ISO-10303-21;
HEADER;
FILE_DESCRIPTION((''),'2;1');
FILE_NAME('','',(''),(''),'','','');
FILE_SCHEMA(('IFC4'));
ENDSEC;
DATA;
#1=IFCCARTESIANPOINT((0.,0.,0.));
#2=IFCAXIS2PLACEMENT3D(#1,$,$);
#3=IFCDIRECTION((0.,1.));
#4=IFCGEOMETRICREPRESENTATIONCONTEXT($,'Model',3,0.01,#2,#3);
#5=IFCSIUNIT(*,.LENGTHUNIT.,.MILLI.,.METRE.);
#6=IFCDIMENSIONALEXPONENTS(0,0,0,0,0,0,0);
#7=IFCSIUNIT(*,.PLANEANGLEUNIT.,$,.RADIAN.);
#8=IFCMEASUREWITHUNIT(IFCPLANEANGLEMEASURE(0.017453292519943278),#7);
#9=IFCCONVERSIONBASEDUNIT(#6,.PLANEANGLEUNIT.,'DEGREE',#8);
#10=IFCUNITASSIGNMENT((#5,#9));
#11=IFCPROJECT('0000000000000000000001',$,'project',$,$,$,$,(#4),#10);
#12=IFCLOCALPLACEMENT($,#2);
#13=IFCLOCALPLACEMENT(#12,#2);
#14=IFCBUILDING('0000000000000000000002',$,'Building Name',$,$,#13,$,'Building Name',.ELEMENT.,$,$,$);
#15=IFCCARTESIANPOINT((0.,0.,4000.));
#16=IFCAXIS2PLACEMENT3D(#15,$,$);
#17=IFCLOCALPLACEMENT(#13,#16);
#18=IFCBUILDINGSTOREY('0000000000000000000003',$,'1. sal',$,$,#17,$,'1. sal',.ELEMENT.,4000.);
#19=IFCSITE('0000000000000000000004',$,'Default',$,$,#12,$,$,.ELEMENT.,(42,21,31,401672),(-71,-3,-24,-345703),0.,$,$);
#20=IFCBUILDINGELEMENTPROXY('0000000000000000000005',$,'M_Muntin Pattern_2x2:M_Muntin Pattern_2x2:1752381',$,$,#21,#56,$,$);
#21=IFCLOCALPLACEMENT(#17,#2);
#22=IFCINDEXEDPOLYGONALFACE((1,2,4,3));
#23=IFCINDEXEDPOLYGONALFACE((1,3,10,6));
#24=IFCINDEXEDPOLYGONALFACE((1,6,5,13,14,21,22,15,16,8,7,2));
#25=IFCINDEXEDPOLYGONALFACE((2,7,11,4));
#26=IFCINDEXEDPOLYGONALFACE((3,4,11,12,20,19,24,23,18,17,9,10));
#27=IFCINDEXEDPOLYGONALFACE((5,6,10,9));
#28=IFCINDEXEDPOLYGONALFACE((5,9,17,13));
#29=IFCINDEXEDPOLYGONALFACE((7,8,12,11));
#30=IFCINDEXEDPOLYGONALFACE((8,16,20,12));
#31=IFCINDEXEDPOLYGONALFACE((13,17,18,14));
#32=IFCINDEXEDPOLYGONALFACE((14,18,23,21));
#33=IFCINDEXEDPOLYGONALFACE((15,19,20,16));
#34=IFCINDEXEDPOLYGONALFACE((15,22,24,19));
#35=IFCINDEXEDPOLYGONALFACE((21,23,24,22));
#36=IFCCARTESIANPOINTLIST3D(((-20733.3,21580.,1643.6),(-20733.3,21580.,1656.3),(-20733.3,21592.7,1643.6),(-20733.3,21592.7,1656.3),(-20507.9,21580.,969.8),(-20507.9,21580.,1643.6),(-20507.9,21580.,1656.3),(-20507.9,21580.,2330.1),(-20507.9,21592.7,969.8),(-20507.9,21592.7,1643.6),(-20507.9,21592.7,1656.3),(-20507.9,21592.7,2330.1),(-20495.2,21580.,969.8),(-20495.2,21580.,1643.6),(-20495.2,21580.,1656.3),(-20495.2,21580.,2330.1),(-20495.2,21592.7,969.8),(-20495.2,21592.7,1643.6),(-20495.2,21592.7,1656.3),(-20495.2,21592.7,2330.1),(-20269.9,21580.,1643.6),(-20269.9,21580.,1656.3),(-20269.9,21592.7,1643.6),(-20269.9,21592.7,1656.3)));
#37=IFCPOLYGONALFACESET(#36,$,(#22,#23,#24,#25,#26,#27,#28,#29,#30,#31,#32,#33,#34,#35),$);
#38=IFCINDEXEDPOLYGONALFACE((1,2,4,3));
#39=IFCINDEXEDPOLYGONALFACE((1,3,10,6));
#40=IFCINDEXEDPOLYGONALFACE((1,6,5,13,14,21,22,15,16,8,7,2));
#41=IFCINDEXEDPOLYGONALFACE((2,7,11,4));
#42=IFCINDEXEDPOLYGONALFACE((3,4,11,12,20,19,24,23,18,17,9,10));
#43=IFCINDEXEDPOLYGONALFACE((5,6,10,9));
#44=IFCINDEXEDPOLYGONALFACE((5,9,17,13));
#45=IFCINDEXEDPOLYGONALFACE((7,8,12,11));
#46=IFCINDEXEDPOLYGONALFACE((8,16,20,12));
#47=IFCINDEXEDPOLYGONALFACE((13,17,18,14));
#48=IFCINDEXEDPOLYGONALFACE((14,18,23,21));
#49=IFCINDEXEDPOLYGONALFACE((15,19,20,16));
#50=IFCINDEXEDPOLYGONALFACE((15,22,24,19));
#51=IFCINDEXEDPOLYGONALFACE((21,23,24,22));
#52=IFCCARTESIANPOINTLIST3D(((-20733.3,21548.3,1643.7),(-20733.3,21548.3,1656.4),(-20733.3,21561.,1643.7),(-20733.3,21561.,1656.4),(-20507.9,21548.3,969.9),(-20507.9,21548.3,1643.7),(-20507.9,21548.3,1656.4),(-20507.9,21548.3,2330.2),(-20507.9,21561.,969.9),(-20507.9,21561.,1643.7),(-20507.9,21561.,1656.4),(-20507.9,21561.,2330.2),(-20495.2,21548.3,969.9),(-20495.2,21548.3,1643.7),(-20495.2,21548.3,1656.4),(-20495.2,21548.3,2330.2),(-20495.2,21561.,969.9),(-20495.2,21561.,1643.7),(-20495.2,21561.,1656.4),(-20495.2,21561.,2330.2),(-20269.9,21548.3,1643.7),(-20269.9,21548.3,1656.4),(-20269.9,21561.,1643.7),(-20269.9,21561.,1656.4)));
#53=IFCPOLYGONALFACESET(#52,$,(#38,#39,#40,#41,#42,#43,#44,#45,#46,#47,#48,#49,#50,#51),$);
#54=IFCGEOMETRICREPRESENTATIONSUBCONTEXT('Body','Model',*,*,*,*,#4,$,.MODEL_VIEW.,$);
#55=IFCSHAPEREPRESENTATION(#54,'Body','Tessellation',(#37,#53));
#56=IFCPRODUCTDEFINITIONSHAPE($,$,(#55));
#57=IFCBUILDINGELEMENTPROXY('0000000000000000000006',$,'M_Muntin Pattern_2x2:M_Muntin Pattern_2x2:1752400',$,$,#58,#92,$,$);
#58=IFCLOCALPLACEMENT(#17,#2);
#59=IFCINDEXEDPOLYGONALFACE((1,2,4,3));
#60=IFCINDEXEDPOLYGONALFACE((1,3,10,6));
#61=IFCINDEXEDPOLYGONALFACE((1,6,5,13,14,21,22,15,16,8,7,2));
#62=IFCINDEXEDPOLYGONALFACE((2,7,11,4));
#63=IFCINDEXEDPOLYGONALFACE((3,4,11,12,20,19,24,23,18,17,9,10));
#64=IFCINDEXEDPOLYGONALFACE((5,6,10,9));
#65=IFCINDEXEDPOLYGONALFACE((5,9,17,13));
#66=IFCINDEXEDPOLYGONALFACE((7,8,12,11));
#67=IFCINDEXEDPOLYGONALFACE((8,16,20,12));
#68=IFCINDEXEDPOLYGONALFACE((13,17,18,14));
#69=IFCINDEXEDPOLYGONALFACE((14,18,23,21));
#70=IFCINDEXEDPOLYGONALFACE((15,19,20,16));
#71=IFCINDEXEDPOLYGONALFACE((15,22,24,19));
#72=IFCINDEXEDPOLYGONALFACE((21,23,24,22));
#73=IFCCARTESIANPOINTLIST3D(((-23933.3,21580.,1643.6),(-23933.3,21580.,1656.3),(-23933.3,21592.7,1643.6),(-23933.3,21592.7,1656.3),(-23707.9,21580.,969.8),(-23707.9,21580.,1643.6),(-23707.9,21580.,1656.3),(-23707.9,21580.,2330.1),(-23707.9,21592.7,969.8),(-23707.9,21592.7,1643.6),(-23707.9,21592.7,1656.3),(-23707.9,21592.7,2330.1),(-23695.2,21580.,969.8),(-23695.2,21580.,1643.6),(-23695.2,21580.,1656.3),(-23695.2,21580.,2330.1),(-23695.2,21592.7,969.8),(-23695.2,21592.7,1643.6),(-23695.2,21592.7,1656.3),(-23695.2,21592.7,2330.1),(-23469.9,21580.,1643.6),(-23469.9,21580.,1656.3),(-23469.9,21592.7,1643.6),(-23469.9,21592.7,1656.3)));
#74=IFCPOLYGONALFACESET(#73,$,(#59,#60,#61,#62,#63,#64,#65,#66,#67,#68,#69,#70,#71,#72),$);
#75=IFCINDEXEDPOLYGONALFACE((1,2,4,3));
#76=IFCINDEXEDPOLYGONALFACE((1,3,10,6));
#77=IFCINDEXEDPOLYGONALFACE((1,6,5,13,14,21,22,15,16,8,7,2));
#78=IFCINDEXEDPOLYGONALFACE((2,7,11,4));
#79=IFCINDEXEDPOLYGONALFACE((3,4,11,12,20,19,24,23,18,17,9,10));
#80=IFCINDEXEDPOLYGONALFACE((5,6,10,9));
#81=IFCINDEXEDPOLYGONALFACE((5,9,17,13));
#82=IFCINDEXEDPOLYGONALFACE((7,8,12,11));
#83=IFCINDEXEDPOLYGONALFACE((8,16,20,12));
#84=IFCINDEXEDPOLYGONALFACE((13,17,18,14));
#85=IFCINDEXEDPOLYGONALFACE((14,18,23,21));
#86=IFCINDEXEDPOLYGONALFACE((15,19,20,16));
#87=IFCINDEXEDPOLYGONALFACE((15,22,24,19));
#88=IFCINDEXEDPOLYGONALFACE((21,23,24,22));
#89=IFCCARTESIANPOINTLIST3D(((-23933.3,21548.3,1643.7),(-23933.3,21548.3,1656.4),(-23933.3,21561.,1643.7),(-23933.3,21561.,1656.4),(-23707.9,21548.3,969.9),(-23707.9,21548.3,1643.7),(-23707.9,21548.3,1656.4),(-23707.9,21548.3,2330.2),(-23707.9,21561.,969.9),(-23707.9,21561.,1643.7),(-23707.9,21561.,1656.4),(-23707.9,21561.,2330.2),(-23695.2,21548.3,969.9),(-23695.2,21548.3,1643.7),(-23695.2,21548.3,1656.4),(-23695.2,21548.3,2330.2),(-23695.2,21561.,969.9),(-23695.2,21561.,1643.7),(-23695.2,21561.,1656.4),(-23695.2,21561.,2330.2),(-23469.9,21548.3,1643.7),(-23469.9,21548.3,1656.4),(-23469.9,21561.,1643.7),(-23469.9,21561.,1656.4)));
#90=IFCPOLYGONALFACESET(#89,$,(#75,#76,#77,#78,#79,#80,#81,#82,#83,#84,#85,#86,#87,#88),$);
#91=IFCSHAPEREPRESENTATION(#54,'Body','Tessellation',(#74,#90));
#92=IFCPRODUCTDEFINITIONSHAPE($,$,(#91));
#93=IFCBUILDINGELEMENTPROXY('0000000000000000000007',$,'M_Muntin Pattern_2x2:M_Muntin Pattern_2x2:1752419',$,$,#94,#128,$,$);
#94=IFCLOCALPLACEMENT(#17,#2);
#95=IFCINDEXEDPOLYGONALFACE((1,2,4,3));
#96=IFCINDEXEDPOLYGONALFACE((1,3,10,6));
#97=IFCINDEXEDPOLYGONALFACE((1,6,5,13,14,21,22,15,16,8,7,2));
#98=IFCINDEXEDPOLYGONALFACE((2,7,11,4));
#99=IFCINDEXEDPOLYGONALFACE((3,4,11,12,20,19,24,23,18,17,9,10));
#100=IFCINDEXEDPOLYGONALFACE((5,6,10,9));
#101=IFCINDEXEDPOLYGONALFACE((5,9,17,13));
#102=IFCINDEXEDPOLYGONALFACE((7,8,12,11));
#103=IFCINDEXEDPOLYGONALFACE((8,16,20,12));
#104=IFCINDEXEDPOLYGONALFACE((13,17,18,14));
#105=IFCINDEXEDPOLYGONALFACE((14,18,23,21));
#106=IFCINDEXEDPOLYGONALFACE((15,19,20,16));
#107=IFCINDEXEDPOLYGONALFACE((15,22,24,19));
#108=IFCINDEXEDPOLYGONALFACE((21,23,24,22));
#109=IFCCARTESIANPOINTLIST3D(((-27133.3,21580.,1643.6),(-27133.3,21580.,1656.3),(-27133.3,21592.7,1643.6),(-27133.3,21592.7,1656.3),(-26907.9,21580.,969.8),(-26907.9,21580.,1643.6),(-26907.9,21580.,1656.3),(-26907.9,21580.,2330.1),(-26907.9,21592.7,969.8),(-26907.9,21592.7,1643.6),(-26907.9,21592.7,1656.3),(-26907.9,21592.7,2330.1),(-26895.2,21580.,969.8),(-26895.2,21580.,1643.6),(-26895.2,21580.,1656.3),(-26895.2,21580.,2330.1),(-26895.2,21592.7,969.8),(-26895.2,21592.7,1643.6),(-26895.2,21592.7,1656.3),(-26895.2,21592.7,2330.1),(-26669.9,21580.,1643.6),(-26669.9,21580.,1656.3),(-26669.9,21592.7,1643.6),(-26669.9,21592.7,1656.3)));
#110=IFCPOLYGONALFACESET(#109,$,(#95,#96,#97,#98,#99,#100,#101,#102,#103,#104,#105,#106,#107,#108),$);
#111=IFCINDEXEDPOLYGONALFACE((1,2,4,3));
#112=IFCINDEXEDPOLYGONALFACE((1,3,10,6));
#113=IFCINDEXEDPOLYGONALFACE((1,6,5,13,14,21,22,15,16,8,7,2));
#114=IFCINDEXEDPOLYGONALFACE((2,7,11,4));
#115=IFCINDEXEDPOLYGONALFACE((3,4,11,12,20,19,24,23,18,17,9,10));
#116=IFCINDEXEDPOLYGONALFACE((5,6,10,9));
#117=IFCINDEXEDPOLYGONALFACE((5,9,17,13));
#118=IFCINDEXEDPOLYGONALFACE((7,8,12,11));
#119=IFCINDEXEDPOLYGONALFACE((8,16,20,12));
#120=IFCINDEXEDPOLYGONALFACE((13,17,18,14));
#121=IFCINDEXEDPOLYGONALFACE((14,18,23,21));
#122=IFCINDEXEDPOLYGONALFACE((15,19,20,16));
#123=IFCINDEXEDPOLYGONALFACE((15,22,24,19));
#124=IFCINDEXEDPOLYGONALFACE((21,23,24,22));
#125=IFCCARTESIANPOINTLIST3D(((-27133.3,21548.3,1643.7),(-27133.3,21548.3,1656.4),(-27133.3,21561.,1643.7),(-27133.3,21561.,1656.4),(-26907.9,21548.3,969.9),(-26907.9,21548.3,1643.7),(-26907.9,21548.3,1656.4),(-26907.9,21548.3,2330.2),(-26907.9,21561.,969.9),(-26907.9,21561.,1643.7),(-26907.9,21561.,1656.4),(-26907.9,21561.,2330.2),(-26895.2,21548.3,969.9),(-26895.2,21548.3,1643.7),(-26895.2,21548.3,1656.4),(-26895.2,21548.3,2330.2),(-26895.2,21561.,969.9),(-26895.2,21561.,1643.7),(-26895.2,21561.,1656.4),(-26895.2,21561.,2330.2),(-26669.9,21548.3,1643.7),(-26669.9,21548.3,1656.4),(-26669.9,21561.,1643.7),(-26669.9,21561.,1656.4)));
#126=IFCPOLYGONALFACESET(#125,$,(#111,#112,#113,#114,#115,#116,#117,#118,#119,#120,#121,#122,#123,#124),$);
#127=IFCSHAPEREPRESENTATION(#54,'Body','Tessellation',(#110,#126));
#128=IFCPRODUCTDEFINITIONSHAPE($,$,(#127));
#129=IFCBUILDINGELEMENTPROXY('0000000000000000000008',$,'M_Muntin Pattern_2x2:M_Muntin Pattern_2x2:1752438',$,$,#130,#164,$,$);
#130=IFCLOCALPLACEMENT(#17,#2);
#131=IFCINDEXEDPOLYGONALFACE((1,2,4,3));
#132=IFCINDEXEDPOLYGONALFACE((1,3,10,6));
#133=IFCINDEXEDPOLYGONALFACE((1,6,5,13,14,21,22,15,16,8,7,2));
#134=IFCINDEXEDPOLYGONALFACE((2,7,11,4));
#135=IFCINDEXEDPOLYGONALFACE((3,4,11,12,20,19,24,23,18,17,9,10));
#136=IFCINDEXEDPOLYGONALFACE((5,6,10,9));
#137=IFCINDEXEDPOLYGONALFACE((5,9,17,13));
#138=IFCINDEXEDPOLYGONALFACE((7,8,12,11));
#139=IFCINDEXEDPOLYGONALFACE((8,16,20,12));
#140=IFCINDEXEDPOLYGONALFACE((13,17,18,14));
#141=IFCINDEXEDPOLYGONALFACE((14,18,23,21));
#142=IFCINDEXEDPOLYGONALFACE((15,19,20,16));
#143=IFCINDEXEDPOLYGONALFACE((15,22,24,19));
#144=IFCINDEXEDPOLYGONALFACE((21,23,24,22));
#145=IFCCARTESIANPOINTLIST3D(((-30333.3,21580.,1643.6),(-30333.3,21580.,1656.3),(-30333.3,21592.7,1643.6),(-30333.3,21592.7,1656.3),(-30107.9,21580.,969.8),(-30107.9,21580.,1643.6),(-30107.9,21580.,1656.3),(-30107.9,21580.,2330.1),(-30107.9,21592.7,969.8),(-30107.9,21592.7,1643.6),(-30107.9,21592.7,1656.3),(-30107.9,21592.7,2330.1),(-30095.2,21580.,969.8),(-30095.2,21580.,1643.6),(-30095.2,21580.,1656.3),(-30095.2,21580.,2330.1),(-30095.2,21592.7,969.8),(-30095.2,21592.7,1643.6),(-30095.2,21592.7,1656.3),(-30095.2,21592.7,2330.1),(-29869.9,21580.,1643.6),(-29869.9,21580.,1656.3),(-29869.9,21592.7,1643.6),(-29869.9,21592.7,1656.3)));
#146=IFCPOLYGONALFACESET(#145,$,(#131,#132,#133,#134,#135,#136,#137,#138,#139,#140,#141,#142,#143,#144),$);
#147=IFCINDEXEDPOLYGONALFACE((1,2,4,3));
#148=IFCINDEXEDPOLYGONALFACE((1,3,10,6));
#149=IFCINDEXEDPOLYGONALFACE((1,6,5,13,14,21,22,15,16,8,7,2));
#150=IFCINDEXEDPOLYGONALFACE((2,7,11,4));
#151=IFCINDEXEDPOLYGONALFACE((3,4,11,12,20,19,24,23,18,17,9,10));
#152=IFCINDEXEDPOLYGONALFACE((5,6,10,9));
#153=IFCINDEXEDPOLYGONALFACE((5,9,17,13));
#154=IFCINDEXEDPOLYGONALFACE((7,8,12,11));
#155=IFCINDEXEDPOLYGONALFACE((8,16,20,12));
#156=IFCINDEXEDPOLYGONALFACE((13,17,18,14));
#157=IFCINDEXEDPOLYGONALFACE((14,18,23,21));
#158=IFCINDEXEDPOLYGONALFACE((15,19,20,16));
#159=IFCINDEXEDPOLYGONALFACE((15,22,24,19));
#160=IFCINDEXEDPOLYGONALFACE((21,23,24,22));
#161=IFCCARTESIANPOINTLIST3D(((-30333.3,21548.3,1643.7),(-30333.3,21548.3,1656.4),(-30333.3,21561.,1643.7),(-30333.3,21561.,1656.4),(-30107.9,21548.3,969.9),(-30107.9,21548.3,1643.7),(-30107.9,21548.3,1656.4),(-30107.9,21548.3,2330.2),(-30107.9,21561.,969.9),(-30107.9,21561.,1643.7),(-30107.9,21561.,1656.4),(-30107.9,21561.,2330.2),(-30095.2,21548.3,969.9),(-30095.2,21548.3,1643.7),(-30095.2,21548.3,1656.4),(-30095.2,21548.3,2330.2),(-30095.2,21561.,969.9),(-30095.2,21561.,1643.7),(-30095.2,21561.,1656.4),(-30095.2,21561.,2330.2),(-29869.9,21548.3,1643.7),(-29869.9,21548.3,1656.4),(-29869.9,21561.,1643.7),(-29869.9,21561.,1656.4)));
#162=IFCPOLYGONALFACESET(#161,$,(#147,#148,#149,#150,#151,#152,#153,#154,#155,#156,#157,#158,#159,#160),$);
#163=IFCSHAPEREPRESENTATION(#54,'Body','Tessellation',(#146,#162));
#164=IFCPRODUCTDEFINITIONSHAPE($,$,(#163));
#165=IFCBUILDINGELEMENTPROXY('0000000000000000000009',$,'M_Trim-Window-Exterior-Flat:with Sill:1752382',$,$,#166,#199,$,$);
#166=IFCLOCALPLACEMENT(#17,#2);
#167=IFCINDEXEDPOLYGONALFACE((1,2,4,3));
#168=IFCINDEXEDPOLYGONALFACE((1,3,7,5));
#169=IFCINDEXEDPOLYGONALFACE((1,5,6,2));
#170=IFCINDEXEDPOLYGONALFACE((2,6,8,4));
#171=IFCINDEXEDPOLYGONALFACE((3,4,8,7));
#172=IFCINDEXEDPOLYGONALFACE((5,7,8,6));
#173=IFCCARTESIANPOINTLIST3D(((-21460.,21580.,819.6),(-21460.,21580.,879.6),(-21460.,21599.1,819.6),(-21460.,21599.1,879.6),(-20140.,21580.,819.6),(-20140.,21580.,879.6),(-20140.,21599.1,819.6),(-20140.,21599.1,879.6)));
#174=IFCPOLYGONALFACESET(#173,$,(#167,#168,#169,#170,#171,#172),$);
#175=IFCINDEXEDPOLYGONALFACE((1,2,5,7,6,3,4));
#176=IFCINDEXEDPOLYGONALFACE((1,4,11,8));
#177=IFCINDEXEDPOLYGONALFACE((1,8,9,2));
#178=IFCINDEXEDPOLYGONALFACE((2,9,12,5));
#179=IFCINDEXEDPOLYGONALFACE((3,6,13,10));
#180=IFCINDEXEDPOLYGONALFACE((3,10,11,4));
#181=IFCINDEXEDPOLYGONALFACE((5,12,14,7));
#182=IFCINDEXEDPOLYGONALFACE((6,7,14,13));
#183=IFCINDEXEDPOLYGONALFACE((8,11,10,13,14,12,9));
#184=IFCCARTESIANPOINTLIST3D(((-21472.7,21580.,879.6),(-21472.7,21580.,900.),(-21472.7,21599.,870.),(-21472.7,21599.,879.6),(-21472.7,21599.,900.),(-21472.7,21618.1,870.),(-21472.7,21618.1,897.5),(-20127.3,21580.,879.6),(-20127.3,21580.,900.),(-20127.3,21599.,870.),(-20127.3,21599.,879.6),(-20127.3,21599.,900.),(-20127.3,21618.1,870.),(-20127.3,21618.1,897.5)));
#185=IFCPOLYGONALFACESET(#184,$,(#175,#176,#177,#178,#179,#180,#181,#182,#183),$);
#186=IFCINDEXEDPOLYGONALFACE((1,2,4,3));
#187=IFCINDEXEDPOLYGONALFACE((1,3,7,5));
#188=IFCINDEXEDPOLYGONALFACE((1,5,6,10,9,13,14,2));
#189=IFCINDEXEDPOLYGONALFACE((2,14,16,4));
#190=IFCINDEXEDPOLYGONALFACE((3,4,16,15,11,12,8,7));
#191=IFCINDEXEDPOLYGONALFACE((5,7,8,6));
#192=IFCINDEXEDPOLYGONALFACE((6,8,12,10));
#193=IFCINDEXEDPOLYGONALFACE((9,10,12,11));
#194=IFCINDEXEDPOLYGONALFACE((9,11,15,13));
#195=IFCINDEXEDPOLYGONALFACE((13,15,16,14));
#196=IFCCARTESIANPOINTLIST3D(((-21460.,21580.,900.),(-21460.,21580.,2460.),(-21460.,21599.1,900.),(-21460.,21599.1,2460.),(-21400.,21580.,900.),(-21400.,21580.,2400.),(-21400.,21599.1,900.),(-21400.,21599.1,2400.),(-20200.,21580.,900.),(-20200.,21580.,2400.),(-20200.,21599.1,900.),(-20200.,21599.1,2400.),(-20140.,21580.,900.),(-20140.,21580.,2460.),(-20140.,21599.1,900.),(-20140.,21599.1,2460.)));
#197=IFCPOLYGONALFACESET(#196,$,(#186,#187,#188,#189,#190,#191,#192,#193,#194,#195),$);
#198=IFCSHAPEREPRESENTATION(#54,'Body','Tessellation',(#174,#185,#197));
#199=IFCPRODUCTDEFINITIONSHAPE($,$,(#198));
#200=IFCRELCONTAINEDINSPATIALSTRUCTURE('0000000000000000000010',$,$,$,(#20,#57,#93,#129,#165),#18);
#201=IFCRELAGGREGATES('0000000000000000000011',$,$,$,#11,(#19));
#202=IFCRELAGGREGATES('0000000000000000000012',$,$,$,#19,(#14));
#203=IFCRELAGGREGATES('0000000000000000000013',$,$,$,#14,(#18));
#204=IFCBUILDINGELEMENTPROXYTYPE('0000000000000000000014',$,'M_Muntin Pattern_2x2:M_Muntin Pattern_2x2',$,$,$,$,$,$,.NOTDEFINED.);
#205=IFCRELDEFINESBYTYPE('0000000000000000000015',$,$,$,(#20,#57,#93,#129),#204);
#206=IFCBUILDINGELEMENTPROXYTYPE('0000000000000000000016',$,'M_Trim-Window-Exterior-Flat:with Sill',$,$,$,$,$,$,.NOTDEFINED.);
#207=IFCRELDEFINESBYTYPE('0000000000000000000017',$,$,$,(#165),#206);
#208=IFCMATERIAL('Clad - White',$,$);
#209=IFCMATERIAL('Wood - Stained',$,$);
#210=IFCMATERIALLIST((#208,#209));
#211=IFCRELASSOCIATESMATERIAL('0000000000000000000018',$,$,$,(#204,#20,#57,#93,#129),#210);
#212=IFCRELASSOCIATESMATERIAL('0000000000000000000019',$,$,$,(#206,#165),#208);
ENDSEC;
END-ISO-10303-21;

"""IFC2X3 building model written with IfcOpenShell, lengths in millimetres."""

from ifc_helpers import new_model, entity, si_unit, converted_unit, direction, frame, frame_2d, origin, place, context, subcontext, project, spatial, polyline, rectangle, outline, extrude, source, transform, mapped, material, material_list, type_object, type_shapes, element, save


model = new_model("IFC2X3")

# Units and contexts
model_context = context("Model", 3, precision=0.01, world=origin(), true_north=direction((0.0, 1.0)))
body_context = subcontext(model_context, "Body", "Model", "MODEL_VIEW")
ifc_project = project(units=[si_unit("LENGTHUNIT", "METRE", prefix="MILLI"), converted_unit("PLANEANGLEUNIT", "DEGREE", entity("IfcPlaneAngleMeasure", 0.017453292519943278), si_unit("PLANEANGLEUNIT", "RADIAN"), dimensions=[0, 0, 0, 0, 0, 0, 0])], contexts=[model_context])

# Site, building, storey
site_placement = place(None, origin())
site = spatial("IfcSite", under=ifc_project, at=site_placement, Name="Default", CompositionType="ELEMENT", RefLatitude=(42, 21, 31, 401672), RefLongitude=(-71, -3, -24, -345703), RefElevation=0.0)
building_placement = place(site_placement, origin())
building = spatial("IfcBuilding", under=site, at=building_placement, Name="Building Name", LongName="Building Name", CompositionType="ELEMENT")
storey_placement = place(building_placement, frame((0.0, 0.0, 4000.0)))
storey = spatial("IfcBuildingStorey", under=building, at=storey_placement, Name="1. sal", LongName="1. sal", CompositionType="ELEMENT", Elevation=4000.0)

# Building element proxies
ifc_material_1 = material(Name="Clad - White")
ifc_material_2 = material(Name="Wood - Stained")
ifc_material_list = material_list([ifc_material_1, ifc_material_2])
building_element_proxy_type_1 = type_object("IfcBuildingElementProxyType", Name="M_Muntin Pattern_2x2:M_Muntin Pattern_2x2", PredefinedType="NOTDEFINED", material=ifc_material_list)
shared_shape_1 = source(origin(), body_context, "Body", "SweptSolid", [
    extrude(outline(polyline([(6.4, -6.4), (680.1, -6.4), (680.1, 6.3), (6.4, 6.3), (6.4, 231.7), (-6.3, 231.7), (-6.3, 6.3), (-680.2, 6.3), (-680.2, -6.4), (-6.3, -6.4), (-6.3, -231.7), (6.4, -231.7), (6.4, -6.4)])), frame((0.0, -22.2, 680.1), z_axis=(0.0, 1.0, 0.0), x_axis=(0.0, 0.0, 1.0)), (0.0, 0.0, 1.0), 12.7),
    extrude(outline(polyline([(6.4, -6.4), (680.2, -6.4), (680.2, 6.3), (6.4, 6.3), (6.4, 231.7), (-6.3, 231.7), (-6.3, 6.3), (-680.2, 6.3), (-680.2, -6.4), (-6.3, -6.4), (-6.3, -231.7), (6.4, -231.7), (6.4, -6.4)])), frame((0.0, 9.5, 680.2), z_axis=(0.0, 1.0, 0.0), x_axis=(0.0, 0.0, 1.0)), (0.0, 0.0, 1.0), 12.7),
])
type_shapes(building_element_proxy_type_1, [shared_shape_1])
for number, where, z_axis, x_axis, name in (
    (1, (-20501.6, 21570.5, 969.9), (0.0, 0.0, 1.0), (-1.0, 0.0, 0.0), "M_Muntin Pattern_2x2:M_Muntin Pattern_2x2:1752381"),
    (2, (-23701.6, 21570.5, 969.9), (0.0, 0.0, 1.0), (-1.0, 0.0, 0.0), "M_Muntin Pattern_2x2:M_Muntin Pattern_2x2:1752400"),
    (3, (-26901.6, 21570.5, 969.9), (0.0, 0.0, 1.0), (-1.0, 0.0, 0.0), "M_Muntin Pattern_2x2:M_Muntin Pattern_2x2:1752419"),
    (4, (-30101.6, 21570.5, 969.9), (0.0, 0.0, 1.0), (-1.0, 0.0, 0.0), "M_Muntin Pattern_2x2:M_Muntin Pattern_2x2:1752438"),
):
    element("IfcBuildingElementProxy", number, at=place(storey_placement, frame(where, z_axis=z_axis, x_axis=x_axis)), inside=storey, type_object=building_element_proxy_type_1, material=ifc_material_list, Name=name, context=body_context, shape_type="MappedRepresentation", body=[
        mapped(shared_shape_1, transform((0.0, 0.0, 0.0), scale=1.0)),
    ])
building_element_proxy_type_2 = type_object("IfcBuildingElementProxyType", Name="M_Trim-Window-Exterior-Flat:with Sill", PredefinedType="NOTDEFINED", material=ifc_material_1)
shared_shape_2 = source(origin(), body_context, "Body", "SweptSolid", [
    extrude(rectangle(XDim=1320.0, YDim=60.0, at=frame_2d((0.0, 0.0), x_axis=(1.0, 0.0))), frame((0.0, -1550.4, 0.0), z_axis=(0.0, 0.0, 1.0), x_axis=(-1.0, 0.0, 0.0)), (0.0, 0.0, 1.0), 19.0),
    extrude(outline(polyline([(-19.0, -15.2), (0.0, -15.2), (0.0, -5.7), (19.0, -5.7), (19.0, 14.8), (0.0, 14.8), (-19.0, 12.3), (-19.0, -15.2)])), frame((-672.7, -1514.8, 19.0), z_axis=(1.0, 0.0, 0.0), x_axis=(0.0, 0.0, -1.0)), (0.0, 0.0, 1.0), 1345.4),
    extrude(outline(polyline([(-795.0, -660.0), (765.0, -660.0), (765.0, -600.0), (-735.0, -600.0), (-735.0, 600.0), (765.0, 600.0), (765.0, 660.0), (-795.0, 660.0), (-795.0, -660.0)])), frame((0.0, -735.0, 0.0), z_axis=(0.0, 0.0, 1.0), x_axis=(0.0, -1.0, 0.0)), (0.0, 0.0, 1.0), 19.0),
])
type_shapes(building_element_proxy_type_2, [shared_shape_2])
for number, where, z_axis, x_axis, name in (
    (5, (-20800.0, 21580.0, 2400.0), (0.0, 1.0, 0.0), (-1.0, 0.0, 0.0), "M_Trim-Window-Exterior-Flat:with Sill:1752382"),
):
    element("IfcBuildingElementProxy", number, at=place(storey_placement, frame(where, z_axis=z_axis, x_axis=x_axis)), inside=storey, type_object=building_element_proxy_type_2, material=ifc_material_1, Name=name, context=body_context, shape_type="MappedRepresentation", body=[
        mapped(shared_shape_2, transform((0.0, 0.0, 0.0), scale=1.0)),
    ])

save(model, "model.ifc")
